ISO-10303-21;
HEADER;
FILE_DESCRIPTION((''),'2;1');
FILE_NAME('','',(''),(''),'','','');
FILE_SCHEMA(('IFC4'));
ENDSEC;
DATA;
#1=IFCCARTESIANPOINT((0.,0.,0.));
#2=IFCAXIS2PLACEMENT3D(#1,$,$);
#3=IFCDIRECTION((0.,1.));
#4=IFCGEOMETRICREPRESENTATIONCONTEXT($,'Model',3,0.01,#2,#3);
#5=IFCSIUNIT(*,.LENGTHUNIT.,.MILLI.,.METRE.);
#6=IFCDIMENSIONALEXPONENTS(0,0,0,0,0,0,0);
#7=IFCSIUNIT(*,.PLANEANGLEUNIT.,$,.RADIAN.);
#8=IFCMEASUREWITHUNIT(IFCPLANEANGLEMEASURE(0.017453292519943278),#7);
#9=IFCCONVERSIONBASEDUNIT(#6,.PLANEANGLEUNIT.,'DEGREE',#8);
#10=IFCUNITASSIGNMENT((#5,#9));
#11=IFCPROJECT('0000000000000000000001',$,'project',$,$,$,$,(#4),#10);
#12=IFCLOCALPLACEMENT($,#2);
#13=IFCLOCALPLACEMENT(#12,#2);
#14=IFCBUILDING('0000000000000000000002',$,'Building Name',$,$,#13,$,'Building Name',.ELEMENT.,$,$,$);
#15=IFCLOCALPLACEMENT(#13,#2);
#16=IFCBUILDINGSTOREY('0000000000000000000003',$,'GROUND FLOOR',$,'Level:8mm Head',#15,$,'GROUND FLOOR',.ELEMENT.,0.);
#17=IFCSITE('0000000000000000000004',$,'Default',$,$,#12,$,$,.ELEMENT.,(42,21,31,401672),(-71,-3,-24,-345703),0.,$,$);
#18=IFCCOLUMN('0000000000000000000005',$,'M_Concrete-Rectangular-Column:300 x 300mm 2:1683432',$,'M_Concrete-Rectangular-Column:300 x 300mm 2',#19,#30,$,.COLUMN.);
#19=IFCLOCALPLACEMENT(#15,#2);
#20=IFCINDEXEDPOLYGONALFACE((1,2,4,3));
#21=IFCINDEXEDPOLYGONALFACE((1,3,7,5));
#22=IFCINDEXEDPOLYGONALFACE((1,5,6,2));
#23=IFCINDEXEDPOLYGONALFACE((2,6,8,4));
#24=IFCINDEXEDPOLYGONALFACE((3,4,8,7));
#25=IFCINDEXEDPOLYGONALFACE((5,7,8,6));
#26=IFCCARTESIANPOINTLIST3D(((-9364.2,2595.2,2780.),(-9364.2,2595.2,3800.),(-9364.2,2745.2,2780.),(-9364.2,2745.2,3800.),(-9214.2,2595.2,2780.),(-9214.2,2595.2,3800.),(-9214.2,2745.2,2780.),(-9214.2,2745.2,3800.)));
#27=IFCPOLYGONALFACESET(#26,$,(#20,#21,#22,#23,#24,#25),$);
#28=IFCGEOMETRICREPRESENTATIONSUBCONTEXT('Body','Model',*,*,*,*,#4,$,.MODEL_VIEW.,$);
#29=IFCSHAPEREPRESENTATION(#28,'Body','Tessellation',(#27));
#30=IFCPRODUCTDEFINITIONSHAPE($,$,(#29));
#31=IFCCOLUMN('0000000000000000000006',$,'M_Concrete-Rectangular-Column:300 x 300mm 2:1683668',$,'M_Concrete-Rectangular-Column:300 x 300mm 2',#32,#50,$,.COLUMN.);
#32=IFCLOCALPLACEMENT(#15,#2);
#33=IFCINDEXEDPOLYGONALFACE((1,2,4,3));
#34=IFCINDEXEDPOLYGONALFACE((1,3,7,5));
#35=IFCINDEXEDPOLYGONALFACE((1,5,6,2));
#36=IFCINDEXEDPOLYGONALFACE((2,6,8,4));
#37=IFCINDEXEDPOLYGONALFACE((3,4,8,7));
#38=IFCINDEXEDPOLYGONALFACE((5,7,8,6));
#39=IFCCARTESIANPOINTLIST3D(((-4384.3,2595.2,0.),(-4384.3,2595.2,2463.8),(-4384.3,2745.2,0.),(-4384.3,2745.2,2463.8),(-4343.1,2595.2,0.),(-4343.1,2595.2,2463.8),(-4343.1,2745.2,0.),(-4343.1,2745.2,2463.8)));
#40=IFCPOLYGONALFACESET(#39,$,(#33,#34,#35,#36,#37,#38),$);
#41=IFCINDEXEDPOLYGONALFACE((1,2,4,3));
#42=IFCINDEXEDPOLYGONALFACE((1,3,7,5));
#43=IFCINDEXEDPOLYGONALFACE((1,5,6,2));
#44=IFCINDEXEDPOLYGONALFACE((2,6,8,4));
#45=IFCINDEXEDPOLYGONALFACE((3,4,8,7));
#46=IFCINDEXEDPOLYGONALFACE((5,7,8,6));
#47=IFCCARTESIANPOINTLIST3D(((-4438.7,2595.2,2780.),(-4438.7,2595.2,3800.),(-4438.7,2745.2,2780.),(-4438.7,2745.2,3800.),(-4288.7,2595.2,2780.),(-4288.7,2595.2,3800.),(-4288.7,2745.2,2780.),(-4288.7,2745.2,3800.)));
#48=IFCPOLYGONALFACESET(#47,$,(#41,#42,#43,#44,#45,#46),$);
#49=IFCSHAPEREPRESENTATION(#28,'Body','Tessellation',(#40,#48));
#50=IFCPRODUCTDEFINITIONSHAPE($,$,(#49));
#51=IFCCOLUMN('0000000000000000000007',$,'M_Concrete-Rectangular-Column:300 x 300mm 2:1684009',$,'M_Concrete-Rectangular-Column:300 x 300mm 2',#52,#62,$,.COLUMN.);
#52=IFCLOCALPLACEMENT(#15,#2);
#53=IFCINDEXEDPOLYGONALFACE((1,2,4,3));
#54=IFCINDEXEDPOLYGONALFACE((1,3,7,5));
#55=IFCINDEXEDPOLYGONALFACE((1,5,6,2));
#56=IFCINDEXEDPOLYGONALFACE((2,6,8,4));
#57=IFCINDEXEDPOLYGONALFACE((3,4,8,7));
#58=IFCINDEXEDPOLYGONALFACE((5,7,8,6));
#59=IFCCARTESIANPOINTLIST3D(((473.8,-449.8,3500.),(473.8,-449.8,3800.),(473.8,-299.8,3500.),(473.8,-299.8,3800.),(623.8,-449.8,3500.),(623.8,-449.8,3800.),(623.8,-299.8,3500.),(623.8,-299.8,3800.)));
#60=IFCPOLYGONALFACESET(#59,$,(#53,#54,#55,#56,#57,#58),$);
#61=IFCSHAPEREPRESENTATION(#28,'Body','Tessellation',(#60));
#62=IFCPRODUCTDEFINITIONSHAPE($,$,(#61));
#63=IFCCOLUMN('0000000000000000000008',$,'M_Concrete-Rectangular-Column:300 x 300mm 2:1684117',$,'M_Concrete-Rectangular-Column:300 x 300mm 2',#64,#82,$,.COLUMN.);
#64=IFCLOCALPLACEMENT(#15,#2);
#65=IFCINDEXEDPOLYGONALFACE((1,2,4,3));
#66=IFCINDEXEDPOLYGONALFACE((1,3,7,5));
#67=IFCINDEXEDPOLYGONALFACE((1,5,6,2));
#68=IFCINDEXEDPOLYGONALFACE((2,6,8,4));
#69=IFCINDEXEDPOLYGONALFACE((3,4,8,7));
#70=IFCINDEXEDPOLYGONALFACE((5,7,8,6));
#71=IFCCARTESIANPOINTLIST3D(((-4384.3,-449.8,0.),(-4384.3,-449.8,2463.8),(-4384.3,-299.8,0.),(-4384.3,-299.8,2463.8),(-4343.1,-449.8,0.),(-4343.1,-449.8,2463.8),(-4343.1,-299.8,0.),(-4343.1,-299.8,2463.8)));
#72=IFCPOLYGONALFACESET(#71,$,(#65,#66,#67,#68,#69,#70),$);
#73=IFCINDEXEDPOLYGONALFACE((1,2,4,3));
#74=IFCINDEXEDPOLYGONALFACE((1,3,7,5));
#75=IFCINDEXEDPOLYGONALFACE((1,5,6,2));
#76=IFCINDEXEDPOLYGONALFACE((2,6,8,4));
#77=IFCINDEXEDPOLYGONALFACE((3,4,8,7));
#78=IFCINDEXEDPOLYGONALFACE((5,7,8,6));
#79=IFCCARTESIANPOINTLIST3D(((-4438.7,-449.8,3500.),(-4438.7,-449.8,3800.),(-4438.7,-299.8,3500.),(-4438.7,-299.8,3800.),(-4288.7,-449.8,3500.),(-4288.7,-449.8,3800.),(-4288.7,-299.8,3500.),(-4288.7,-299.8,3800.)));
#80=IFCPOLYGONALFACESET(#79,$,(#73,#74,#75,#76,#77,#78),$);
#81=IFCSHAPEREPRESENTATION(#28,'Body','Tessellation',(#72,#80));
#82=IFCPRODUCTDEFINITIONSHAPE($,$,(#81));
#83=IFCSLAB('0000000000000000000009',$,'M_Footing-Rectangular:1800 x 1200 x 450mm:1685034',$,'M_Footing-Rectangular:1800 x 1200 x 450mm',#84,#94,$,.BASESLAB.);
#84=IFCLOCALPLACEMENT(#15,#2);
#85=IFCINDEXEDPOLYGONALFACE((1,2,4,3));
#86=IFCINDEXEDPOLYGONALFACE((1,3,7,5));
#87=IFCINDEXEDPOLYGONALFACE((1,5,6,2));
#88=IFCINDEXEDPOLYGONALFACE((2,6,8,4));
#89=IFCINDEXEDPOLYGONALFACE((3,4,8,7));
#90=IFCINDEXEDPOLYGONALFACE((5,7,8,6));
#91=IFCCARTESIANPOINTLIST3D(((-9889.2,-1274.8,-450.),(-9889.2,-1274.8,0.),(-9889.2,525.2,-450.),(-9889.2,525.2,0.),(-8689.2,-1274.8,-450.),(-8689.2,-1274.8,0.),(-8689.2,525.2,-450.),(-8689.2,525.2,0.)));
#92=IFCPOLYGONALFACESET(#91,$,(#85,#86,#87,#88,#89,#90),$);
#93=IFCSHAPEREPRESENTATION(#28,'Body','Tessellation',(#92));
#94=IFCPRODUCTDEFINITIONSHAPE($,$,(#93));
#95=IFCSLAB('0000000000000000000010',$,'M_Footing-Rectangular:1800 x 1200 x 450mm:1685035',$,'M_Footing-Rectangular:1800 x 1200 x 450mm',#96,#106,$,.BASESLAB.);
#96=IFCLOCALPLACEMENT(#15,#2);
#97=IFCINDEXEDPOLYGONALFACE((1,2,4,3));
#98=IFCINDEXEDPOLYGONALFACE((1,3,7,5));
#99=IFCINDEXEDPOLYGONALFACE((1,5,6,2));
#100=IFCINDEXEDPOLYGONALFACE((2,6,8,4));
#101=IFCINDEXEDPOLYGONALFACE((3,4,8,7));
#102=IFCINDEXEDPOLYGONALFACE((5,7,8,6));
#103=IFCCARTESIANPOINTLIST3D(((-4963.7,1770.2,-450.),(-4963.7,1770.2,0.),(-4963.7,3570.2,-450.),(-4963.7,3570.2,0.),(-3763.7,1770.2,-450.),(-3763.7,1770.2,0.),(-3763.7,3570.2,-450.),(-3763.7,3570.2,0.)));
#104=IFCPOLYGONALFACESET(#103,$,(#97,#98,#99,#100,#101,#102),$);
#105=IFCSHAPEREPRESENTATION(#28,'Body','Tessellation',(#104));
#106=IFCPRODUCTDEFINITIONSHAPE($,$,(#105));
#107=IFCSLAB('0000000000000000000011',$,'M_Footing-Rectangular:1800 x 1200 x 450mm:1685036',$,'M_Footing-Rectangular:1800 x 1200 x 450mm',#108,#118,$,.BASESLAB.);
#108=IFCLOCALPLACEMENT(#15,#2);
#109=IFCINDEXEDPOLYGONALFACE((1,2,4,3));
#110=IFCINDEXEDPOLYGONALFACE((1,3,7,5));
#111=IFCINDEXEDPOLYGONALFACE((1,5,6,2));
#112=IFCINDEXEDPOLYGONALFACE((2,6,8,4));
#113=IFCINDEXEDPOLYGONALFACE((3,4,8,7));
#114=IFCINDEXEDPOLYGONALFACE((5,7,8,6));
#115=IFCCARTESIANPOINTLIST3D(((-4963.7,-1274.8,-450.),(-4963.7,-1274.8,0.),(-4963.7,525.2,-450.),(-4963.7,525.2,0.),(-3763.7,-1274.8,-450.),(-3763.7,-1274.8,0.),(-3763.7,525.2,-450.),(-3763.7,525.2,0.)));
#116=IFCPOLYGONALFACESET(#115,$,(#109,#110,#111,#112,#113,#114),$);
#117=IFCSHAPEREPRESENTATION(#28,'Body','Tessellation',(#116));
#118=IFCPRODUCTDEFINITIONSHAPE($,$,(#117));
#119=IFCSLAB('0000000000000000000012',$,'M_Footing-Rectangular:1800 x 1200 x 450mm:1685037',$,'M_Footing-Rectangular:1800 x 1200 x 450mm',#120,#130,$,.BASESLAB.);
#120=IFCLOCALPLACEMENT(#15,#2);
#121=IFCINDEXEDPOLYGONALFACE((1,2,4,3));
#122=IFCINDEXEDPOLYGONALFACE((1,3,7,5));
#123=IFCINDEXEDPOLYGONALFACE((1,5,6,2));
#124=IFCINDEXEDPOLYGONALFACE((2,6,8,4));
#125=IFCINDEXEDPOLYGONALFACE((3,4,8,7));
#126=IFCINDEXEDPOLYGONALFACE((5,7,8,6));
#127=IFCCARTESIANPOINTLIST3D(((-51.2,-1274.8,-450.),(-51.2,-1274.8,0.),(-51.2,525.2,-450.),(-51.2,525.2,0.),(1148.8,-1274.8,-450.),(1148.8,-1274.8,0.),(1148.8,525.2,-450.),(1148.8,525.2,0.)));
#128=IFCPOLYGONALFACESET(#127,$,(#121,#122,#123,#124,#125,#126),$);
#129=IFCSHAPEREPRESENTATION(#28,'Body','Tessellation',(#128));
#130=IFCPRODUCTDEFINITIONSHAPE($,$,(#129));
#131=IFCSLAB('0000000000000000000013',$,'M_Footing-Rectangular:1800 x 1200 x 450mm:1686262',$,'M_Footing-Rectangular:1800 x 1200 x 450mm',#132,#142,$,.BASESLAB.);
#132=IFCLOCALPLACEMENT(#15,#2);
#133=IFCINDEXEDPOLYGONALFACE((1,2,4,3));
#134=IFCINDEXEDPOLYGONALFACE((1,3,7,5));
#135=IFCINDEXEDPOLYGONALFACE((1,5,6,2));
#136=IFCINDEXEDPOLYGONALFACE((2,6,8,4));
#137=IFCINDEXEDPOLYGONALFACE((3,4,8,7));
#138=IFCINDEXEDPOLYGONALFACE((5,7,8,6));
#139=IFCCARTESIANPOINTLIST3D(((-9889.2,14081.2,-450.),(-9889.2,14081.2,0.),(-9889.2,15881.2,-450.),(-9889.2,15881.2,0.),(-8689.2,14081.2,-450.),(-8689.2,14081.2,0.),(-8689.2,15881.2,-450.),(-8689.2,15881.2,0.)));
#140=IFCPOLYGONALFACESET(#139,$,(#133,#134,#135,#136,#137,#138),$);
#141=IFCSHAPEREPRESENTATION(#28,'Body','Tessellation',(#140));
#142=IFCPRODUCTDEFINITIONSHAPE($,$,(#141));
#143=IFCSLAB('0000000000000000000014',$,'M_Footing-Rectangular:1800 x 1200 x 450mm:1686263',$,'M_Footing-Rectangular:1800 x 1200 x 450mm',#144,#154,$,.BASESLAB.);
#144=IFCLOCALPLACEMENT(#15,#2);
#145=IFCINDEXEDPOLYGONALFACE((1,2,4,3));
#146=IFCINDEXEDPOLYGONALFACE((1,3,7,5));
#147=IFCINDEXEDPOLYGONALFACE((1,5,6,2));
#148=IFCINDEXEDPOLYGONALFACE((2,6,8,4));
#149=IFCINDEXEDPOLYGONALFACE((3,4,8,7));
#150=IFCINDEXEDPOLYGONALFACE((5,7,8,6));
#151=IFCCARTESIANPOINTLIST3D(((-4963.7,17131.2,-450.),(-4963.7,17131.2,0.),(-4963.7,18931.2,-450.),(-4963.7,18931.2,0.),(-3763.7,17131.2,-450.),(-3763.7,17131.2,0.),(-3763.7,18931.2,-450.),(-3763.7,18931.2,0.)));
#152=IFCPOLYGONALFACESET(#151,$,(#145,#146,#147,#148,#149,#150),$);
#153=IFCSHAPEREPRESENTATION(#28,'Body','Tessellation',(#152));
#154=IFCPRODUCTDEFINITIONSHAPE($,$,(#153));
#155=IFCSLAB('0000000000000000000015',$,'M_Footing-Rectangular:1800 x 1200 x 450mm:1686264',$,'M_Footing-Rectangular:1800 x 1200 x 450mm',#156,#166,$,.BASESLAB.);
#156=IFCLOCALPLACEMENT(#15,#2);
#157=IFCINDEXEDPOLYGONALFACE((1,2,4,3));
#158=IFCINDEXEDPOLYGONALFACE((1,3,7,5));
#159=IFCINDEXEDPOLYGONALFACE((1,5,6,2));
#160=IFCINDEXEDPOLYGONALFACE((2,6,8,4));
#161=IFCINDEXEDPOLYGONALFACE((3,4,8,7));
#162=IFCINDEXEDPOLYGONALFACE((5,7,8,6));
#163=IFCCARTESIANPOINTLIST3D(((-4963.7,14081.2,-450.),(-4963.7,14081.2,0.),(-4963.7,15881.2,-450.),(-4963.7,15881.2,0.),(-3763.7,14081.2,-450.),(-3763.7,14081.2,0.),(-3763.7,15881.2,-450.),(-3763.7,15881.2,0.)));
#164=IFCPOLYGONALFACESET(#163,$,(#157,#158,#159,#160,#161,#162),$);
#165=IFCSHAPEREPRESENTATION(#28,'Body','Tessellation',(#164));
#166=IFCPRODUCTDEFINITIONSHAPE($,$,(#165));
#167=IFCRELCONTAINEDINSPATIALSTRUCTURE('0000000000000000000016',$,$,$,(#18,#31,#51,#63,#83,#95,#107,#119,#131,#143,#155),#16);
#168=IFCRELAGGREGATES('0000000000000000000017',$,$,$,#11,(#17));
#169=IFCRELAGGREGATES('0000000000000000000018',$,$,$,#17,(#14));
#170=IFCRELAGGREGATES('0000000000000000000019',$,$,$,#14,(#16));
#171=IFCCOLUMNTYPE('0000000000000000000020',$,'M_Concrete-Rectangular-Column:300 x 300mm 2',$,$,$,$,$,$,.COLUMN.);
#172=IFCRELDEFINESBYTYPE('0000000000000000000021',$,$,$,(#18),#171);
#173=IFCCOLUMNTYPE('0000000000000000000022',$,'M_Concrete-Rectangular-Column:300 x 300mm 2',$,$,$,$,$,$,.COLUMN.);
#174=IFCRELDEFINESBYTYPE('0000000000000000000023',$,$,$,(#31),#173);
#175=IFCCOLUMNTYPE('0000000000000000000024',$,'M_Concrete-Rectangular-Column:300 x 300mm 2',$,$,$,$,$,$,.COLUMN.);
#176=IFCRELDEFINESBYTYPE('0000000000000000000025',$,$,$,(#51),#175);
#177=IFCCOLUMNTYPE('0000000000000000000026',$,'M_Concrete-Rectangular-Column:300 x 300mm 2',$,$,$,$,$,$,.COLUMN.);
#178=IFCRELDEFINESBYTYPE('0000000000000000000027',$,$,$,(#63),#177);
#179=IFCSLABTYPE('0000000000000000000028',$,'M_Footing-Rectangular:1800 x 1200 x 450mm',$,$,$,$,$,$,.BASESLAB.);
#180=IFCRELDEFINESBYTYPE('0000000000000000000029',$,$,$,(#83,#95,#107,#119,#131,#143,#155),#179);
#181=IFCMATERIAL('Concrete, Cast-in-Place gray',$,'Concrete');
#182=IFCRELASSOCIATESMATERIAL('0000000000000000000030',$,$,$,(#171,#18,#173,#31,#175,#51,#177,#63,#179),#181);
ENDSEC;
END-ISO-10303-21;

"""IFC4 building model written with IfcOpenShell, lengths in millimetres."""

from ifc_helpers import new_model, entity, si_unit, converted_unit, direction, frame, origin, place, context, subcontext, project, spatial, indexed_curve, outline, extrude, source, transform, mapped, material, type_object, type_shapes, element, save


model = new_model("IFC4")

# Units and contexts
model_context = context("Model", 3, precision=0.01, world=origin(), true_north=direction((0.0, 1.0)))
body_context = subcontext(model_context, "Body", "Model", "MODEL_VIEW")
ifc_project = project(units=[si_unit("LENGTHUNIT", "METRE", prefix="MILLI"), converted_unit("PLANEANGLEUNIT", "DEGREE", entity("IfcPlaneAngleMeasure", 0.017453292519943278), si_unit("PLANEANGLEUNIT", "RADIAN"), dimensions=[0, 0, 0, 0, 0, 0, 0])], contexts=[model_context])

# Site, building, storey
site_placement = place(None, origin())
site = spatial("IfcSite", under=ifc_project, at=site_placement, Name="Default", CompositionType="ELEMENT", RefLatitude=(42, 21, 31, 401672), RefLongitude=(-71, -3, -24, -345703), RefElevation=0.0)
building_placement = place(site_placement, origin())
building = spatial("IfcBuilding", under=site, at=building_placement, Name="Building Name", LongName="Building Name", CompositionType="ELEMENT")
storey_placement = place(building_placement, origin())
storey = spatial("IfcBuildingStorey", under=building, at=storey_placement, Name="GROUND FLOOR", ObjectType="Level:8mm Head", LongName="GROUND FLOOR", CompositionType="ELEMENT", Elevation=0.0)

# Columns
ifc_material_1 = material(Name="Concrete, Cast-in-Place gray", Category="Concrete")
column_type_1 = type_object("IfcColumnType", Name="M_Concrete-Rectangular-Column:300 x 300mm 2", PredefinedType="COLUMN", material=ifc_material_1)
shared_shape_1 = source(origin(), body_context, "Body", "SweptSolid", [
    extrude(outline(indexed_curve([(-75.0, -75.0), (75.0, -75.0), (75.0, 75.0), (-75.0, 75.0), (-75.0, -75.0)], self_intersect=False)), frame((-9289.2, 2670.2, 2780.0), z_axis=(0.0, 0.0, 1.0), x_axis=(-1.0, 0.0, 0.0)), (0.0, 0.0, 1.0), 1020.0),
])
type_shapes(column_type_1, [shared_shape_1])
column_1_placement = place(storey_placement, origin())
element("IfcColumn", 1, at=column_1_placement, inside=storey, type_object=column_type_1, material=ifc_material_1, Name="M_Concrete-Rectangular-Column:300 x 300mm 2:1683432", ObjectType="M_Concrete-Rectangular-Column:300 x 300mm 2", PredefinedType="COLUMN", context=body_context, shape_type="MappedRepresentation", body=[
    mapped(shared_shape_1, transform((0.0, 0.0, 0.0), scale=1.0)),
])
column_type_2 = type_object("IfcColumnType", Name="M_Concrete-Rectangular-Column:300 x 300mm 2", PredefinedType="COLUMN", material=ifc_material_1)
shared_shape_2 = source(origin(), body_context, "Body", "SweptSolid", [
    extrude(outline(indexed_curve([(-1231.9, -75.0), (1231.9, -75.0), (1231.9, 75.0), (-1231.9, 75.0), (-1231.9, -75.0)], self_intersect=False)), frame((-4384.3, 2670.2, 1231.9), z_axis=(1.0, 0.0, 0.0), x_axis=(0.0, 0.0, -1.0)), (0.0, 0.0, 1.0), 41.3),
    extrude(outline(indexed_curve([(-75.0, -75.0), (75.0, -75.0), (75.0, 75.0), (-75.0, 75.0), (-75.0, -75.0)], self_intersect=False)), frame((-4363.7, 2670.2, 2780.0), z_axis=(0.0, 0.0, 1.0), x_axis=(-1.0, 0.0, 0.0)), (0.0, 0.0, 1.0), 1020.0),
])
type_shapes(column_type_2, [shared_shape_2])
column_2_placement = place(storey_placement, origin())
element("IfcColumn", 2, at=column_2_placement, inside=storey, type_object=column_type_2, material=ifc_material_1, Name="M_Concrete-Rectangular-Column:300 x 300mm 2:1683668", ObjectType="M_Concrete-Rectangular-Column:300 x 300mm 2", PredefinedType="COLUMN", context=body_context, shape_type="MappedRepresentation", body=[
    mapped(shared_shape_2, transform((0.0, 0.0, 0.0), scale=1.0)),
])
column_type_3 = type_object("IfcColumnType", Name="M_Concrete-Rectangular-Column:300 x 300mm 2", PredefinedType="COLUMN", material=ifc_material_1)
shared_shape_3 = source(origin(), body_context, "Body", "SweptSolid", [
    extrude(outline(indexed_curve([(-75.0, -75.0), (75.0, -75.0), (75.0, 75.0), (-75.0, 75.0), (-75.0, -75.0)], self_intersect=False)), frame((548.8, -374.8, 3500.0), z_axis=(0.0, 0.0, 1.0), x_axis=(-1.0, 0.0, 0.0)), (0.0, 0.0, 1.0), 300.0),
])
type_shapes(column_type_3, [shared_shape_3])
column_3_placement = place(storey_placement, origin())
element("IfcColumn", 3, at=column_3_placement, inside=storey, type_object=column_type_3, material=ifc_material_1, Name="M_Concrete-Rectangular-Column:300 x 300mm 2:1684009", ObjectType="M_Concrete-Rectangular-Column:300 x 300mm 2", PredefinedType="COLUMN", context=body_context, shape_type="MappedRepresentation", body=[
    mapped(shared_shape_3, transform((0.0, 0.0, 0.0), scale=1.0)),
])
column_type_4 = type_object("IfcColumnType", Name="M_Concrete-Rectangular-Column:300 x 300mm 2", PredefinedType="COLUMN", material=ifc_material_1)
shared_shape_4 = source(origin(), body_context, "Body", "SweptSolid", [
    extrude(outline(indexed_curve([(-1231.9, -75.0), (1231.9, -75.0), (1231.9, 75.0), (-1231.9, 75.0), (-1231.9, -75.0)], self_intersect=False)), frame((-4384.3, -374.8, 1231.9), z_axis=(1.0, 0.0, 0.0), x_axis=(0.0, 0.0, -1.0)), (0.0, 0.0, 1.0), 41.3),
    extrude(outline(indexed_curve([(-75.0, -75.0), (75.0, -75.0), (75.0, 75.0), (-75.0, 75.0), (-75.0, -75.0)], self_intersect=False)), frame((-4363.7, -374.8, 3500.0), z_axis=(0.0, 0.0, 1.0), x_axis=(-1.0, 0.0, 0.0)), (0.0, 0.0, 1.0), 300.0),
])
type_shapes(column_type_4, [shared_shape_4])
column_4_placement = place(storey_placement, origin())
element("IfcColumn", 4, at=column_4_placement, inside=storey, type_object=column_type_4, material=ifc_material_1, Name="M_Concrete-Rectangular-Column:300 x 300mm 2:1684117", ObjectType="M_Concrete-Rectangular-Column:300 x 300mm 2", PredefinedType="COLUMN", context=body_context, shape_type="MappedRepresentation", body=[
    mapped(shared_shape_4, transform((0.0, 0.0, 0.0), scale=1.0)),
])

# Slabs
slab_type_1 = type_object("IfcSlabType", Name="M_Footing-Rectangular:1800 x 1200 x 450mm", PredefinedType="BASESLAB", material=ifc_material_1)
slab_1_placement = place(storey_placement, origin())
element("IfcSlab", 5, at=slab_1_placement, inside=storey, type_object=slab_type_1, Name="M_Footing-Rectangular:1800 x 1200 x 450mm:1685034", ObjectType="M_Footing-Rectangular:1800 x 1200 x 450mm", PredefinedType="BASESLAB", context=body_context, shape_type="SweptSolid", body=[
    extrude(outline(indexed_curve([(-600.0, -900.0), (600.0, -900.0), (600.0, 900.0), (-600.0, 900.0), (-600.0, -900.0)], self_intersect=False)), frame((-9289.2, -374.8, -450.0), z_axis=(0.0, 0.0, 1.0), x_axis=(-1.0, 0.0, 0.0)), (0.0, 0.0, 1.0), 450.0),
])
slab_2_placement = place(storey_placement, origin())
element("IfcSlab", 6, at=slab_2_placement, inside=storey, type_object=slab_type_1, Name="M_Footing-Rectangular:1800 x 1200 x 450mm:1685035", ObjectType="M_Footing-Rectangular:1800 x 1200 x 450mm", PredefinedType="BASESLAB", context=body_context, shape_type="SweptSolid", body=[
    extrude(outline(indexed_curve([(-600.0, -900.0), (600.0, -900.0), (600.0, 900.0), (-600.0, 900.0), (-600.0, -900.0)], self_intersect=False)), frame((-4363.7, 2670.2, -450.0), z_axis=(0.0, 0.0, 1.0), x_axis=(-1.0, 0.0, 0.0)), (0.0, 0.0, 1.0), 450.0),
])
slab_3_placement = place(storey_placement, origin())
element("IfcSlab", 7, at=slab_3_placement, inside=storey, type_object=slab_type_1, Name="M_Footing-Rectangular:1800 x 1200 x 450mm:1685036", ObjectType="M_Footing-Rectangular:1800 x 1200 x 450mm", PredefinedType="BASESLAB", context=body_context, shape_type="SweptSolid", body=[
    extrude(outline(indexed_curve([(-600.0, -900.0), (600.0, -900.0), (600.0, 900.0), (-600.0, 900.0), (-600.0, -900.0)], self_intersect=False)), frame((-4363.7, -374.8, -450.0), z_axis=(0.0, 0.0, 1.0), x_axis=(-1.0, 0.0, 0.0)), (0.0, 0.0, 1.0), 450.0),
])
slab_4_placement = place(storey_placement, origin())
element("IfcSlab", 8, at=slab_4_placement, inside=storey, type_object=slab_type_1, Name="M_Footing-Rectangular:1800 x 1200 x 450mm:1685037", ObjectType="M_Footing-Rectangular:1800 x 1200 x 450mm", PredefinedType="BASESLAB", context=body_context, shape_type="SweptSolid", body=[
    extrude(outline(indexed_curve([(-600.0, -900.0), (600.0, -900.0), (600.0, 900.0), (-600.0, 900.0), (-600.0, -900.0)], self_intersect=False)), frame((548.8, -374.8, -450.0), z_axis=(0.0, 0.0, 1.0), x_axis=(-1.0, 0.0, 0.0)), (0.0, 0.0, 1.0), 450.0),
])
slab_5_placement = place(storey_placement, origin())
element("IfcSlab", 9, at=slab_5_placement, inside=storey, type_object=slab_type_1, Name="M_Footing-Rectangular:1800 x 1200 x 450mm:1686262", ObjectType="M_Footing-Rectangular:1800 x 1200 x 450mm", PredefinedType="BASESLAB", context=body_context, shape_type="SweptSolid", body=[
    extrude(outline(indexed_curve([(-600.0, -900.0), (600.0, -900.0), (600.0, 900.0), (-600.0, 900.0), (-600.0, -900.0)], self_intersect=False)), frame((-9289.2, 14981.2, -450.0), z_axis=(0.0, 0.0, 1.0), x_axis=(-1.0, 0.0, 0.0)), (0.0, 0.0, 1.0), 450.0),
])
slab_6_placement = place(storey_placement, origin())
element("IfcSlab", 10, at=slab_6_placement, inside=storey, type_object=slab_type_1, Name="M_Footing-Rectangular:1800 x 1200 x 450mm:1686263", ObjectType="M_Footing-Rectangular:1800 x 1200 x 450mm", PredefinedType="BASESLAB", context=body_context, shape_type="SweptSolid", body=[
    extrude(outline(indexed_curve([(-600.0, -900.0), (600.0, -900.0), (600.0, 900.0), (-600.0, 900.0), (-600.0, -900.0)], self_intersect=False)), frame((-4363.7, 18031.2, -450.0), z_axis=(0.0, 0.0, 1.0), x_axis=(-1.0, 0.0, 0.0)), (0.0, 0.0, 1.0), 450.0),
])
slab_7_placement = place(storey_placement, origin())
element("IfcSlab", 11, at=slab_7_placement, inside=storey, type_object=slab_type_1, Name="M_Footing-Rectangular:1800 x 1200 x 450mm:1686264", ObjectType="M_Footing-Rectangular:1800 x 1200 x 450mm", PredefinedType="BASESLAB", context=body_context, shape_type="SweptSolid", body=[
    extrude(outline(indexed_curve([(-600.0, -900.0), (600.0, -900.0), (600.0, 900.0), (-600.0, 900.0), (-600.0, -900.0)], self_intersect=False)), frame((-4363.7, 14981.2, -450.0), z_axis=(0.0, 0.0, 1.0), x_axis=(-1.0, 0.0, 0.0)), (0.0, 0.0, 1.0), 450.0),
])

save(model, "model.ifc")
